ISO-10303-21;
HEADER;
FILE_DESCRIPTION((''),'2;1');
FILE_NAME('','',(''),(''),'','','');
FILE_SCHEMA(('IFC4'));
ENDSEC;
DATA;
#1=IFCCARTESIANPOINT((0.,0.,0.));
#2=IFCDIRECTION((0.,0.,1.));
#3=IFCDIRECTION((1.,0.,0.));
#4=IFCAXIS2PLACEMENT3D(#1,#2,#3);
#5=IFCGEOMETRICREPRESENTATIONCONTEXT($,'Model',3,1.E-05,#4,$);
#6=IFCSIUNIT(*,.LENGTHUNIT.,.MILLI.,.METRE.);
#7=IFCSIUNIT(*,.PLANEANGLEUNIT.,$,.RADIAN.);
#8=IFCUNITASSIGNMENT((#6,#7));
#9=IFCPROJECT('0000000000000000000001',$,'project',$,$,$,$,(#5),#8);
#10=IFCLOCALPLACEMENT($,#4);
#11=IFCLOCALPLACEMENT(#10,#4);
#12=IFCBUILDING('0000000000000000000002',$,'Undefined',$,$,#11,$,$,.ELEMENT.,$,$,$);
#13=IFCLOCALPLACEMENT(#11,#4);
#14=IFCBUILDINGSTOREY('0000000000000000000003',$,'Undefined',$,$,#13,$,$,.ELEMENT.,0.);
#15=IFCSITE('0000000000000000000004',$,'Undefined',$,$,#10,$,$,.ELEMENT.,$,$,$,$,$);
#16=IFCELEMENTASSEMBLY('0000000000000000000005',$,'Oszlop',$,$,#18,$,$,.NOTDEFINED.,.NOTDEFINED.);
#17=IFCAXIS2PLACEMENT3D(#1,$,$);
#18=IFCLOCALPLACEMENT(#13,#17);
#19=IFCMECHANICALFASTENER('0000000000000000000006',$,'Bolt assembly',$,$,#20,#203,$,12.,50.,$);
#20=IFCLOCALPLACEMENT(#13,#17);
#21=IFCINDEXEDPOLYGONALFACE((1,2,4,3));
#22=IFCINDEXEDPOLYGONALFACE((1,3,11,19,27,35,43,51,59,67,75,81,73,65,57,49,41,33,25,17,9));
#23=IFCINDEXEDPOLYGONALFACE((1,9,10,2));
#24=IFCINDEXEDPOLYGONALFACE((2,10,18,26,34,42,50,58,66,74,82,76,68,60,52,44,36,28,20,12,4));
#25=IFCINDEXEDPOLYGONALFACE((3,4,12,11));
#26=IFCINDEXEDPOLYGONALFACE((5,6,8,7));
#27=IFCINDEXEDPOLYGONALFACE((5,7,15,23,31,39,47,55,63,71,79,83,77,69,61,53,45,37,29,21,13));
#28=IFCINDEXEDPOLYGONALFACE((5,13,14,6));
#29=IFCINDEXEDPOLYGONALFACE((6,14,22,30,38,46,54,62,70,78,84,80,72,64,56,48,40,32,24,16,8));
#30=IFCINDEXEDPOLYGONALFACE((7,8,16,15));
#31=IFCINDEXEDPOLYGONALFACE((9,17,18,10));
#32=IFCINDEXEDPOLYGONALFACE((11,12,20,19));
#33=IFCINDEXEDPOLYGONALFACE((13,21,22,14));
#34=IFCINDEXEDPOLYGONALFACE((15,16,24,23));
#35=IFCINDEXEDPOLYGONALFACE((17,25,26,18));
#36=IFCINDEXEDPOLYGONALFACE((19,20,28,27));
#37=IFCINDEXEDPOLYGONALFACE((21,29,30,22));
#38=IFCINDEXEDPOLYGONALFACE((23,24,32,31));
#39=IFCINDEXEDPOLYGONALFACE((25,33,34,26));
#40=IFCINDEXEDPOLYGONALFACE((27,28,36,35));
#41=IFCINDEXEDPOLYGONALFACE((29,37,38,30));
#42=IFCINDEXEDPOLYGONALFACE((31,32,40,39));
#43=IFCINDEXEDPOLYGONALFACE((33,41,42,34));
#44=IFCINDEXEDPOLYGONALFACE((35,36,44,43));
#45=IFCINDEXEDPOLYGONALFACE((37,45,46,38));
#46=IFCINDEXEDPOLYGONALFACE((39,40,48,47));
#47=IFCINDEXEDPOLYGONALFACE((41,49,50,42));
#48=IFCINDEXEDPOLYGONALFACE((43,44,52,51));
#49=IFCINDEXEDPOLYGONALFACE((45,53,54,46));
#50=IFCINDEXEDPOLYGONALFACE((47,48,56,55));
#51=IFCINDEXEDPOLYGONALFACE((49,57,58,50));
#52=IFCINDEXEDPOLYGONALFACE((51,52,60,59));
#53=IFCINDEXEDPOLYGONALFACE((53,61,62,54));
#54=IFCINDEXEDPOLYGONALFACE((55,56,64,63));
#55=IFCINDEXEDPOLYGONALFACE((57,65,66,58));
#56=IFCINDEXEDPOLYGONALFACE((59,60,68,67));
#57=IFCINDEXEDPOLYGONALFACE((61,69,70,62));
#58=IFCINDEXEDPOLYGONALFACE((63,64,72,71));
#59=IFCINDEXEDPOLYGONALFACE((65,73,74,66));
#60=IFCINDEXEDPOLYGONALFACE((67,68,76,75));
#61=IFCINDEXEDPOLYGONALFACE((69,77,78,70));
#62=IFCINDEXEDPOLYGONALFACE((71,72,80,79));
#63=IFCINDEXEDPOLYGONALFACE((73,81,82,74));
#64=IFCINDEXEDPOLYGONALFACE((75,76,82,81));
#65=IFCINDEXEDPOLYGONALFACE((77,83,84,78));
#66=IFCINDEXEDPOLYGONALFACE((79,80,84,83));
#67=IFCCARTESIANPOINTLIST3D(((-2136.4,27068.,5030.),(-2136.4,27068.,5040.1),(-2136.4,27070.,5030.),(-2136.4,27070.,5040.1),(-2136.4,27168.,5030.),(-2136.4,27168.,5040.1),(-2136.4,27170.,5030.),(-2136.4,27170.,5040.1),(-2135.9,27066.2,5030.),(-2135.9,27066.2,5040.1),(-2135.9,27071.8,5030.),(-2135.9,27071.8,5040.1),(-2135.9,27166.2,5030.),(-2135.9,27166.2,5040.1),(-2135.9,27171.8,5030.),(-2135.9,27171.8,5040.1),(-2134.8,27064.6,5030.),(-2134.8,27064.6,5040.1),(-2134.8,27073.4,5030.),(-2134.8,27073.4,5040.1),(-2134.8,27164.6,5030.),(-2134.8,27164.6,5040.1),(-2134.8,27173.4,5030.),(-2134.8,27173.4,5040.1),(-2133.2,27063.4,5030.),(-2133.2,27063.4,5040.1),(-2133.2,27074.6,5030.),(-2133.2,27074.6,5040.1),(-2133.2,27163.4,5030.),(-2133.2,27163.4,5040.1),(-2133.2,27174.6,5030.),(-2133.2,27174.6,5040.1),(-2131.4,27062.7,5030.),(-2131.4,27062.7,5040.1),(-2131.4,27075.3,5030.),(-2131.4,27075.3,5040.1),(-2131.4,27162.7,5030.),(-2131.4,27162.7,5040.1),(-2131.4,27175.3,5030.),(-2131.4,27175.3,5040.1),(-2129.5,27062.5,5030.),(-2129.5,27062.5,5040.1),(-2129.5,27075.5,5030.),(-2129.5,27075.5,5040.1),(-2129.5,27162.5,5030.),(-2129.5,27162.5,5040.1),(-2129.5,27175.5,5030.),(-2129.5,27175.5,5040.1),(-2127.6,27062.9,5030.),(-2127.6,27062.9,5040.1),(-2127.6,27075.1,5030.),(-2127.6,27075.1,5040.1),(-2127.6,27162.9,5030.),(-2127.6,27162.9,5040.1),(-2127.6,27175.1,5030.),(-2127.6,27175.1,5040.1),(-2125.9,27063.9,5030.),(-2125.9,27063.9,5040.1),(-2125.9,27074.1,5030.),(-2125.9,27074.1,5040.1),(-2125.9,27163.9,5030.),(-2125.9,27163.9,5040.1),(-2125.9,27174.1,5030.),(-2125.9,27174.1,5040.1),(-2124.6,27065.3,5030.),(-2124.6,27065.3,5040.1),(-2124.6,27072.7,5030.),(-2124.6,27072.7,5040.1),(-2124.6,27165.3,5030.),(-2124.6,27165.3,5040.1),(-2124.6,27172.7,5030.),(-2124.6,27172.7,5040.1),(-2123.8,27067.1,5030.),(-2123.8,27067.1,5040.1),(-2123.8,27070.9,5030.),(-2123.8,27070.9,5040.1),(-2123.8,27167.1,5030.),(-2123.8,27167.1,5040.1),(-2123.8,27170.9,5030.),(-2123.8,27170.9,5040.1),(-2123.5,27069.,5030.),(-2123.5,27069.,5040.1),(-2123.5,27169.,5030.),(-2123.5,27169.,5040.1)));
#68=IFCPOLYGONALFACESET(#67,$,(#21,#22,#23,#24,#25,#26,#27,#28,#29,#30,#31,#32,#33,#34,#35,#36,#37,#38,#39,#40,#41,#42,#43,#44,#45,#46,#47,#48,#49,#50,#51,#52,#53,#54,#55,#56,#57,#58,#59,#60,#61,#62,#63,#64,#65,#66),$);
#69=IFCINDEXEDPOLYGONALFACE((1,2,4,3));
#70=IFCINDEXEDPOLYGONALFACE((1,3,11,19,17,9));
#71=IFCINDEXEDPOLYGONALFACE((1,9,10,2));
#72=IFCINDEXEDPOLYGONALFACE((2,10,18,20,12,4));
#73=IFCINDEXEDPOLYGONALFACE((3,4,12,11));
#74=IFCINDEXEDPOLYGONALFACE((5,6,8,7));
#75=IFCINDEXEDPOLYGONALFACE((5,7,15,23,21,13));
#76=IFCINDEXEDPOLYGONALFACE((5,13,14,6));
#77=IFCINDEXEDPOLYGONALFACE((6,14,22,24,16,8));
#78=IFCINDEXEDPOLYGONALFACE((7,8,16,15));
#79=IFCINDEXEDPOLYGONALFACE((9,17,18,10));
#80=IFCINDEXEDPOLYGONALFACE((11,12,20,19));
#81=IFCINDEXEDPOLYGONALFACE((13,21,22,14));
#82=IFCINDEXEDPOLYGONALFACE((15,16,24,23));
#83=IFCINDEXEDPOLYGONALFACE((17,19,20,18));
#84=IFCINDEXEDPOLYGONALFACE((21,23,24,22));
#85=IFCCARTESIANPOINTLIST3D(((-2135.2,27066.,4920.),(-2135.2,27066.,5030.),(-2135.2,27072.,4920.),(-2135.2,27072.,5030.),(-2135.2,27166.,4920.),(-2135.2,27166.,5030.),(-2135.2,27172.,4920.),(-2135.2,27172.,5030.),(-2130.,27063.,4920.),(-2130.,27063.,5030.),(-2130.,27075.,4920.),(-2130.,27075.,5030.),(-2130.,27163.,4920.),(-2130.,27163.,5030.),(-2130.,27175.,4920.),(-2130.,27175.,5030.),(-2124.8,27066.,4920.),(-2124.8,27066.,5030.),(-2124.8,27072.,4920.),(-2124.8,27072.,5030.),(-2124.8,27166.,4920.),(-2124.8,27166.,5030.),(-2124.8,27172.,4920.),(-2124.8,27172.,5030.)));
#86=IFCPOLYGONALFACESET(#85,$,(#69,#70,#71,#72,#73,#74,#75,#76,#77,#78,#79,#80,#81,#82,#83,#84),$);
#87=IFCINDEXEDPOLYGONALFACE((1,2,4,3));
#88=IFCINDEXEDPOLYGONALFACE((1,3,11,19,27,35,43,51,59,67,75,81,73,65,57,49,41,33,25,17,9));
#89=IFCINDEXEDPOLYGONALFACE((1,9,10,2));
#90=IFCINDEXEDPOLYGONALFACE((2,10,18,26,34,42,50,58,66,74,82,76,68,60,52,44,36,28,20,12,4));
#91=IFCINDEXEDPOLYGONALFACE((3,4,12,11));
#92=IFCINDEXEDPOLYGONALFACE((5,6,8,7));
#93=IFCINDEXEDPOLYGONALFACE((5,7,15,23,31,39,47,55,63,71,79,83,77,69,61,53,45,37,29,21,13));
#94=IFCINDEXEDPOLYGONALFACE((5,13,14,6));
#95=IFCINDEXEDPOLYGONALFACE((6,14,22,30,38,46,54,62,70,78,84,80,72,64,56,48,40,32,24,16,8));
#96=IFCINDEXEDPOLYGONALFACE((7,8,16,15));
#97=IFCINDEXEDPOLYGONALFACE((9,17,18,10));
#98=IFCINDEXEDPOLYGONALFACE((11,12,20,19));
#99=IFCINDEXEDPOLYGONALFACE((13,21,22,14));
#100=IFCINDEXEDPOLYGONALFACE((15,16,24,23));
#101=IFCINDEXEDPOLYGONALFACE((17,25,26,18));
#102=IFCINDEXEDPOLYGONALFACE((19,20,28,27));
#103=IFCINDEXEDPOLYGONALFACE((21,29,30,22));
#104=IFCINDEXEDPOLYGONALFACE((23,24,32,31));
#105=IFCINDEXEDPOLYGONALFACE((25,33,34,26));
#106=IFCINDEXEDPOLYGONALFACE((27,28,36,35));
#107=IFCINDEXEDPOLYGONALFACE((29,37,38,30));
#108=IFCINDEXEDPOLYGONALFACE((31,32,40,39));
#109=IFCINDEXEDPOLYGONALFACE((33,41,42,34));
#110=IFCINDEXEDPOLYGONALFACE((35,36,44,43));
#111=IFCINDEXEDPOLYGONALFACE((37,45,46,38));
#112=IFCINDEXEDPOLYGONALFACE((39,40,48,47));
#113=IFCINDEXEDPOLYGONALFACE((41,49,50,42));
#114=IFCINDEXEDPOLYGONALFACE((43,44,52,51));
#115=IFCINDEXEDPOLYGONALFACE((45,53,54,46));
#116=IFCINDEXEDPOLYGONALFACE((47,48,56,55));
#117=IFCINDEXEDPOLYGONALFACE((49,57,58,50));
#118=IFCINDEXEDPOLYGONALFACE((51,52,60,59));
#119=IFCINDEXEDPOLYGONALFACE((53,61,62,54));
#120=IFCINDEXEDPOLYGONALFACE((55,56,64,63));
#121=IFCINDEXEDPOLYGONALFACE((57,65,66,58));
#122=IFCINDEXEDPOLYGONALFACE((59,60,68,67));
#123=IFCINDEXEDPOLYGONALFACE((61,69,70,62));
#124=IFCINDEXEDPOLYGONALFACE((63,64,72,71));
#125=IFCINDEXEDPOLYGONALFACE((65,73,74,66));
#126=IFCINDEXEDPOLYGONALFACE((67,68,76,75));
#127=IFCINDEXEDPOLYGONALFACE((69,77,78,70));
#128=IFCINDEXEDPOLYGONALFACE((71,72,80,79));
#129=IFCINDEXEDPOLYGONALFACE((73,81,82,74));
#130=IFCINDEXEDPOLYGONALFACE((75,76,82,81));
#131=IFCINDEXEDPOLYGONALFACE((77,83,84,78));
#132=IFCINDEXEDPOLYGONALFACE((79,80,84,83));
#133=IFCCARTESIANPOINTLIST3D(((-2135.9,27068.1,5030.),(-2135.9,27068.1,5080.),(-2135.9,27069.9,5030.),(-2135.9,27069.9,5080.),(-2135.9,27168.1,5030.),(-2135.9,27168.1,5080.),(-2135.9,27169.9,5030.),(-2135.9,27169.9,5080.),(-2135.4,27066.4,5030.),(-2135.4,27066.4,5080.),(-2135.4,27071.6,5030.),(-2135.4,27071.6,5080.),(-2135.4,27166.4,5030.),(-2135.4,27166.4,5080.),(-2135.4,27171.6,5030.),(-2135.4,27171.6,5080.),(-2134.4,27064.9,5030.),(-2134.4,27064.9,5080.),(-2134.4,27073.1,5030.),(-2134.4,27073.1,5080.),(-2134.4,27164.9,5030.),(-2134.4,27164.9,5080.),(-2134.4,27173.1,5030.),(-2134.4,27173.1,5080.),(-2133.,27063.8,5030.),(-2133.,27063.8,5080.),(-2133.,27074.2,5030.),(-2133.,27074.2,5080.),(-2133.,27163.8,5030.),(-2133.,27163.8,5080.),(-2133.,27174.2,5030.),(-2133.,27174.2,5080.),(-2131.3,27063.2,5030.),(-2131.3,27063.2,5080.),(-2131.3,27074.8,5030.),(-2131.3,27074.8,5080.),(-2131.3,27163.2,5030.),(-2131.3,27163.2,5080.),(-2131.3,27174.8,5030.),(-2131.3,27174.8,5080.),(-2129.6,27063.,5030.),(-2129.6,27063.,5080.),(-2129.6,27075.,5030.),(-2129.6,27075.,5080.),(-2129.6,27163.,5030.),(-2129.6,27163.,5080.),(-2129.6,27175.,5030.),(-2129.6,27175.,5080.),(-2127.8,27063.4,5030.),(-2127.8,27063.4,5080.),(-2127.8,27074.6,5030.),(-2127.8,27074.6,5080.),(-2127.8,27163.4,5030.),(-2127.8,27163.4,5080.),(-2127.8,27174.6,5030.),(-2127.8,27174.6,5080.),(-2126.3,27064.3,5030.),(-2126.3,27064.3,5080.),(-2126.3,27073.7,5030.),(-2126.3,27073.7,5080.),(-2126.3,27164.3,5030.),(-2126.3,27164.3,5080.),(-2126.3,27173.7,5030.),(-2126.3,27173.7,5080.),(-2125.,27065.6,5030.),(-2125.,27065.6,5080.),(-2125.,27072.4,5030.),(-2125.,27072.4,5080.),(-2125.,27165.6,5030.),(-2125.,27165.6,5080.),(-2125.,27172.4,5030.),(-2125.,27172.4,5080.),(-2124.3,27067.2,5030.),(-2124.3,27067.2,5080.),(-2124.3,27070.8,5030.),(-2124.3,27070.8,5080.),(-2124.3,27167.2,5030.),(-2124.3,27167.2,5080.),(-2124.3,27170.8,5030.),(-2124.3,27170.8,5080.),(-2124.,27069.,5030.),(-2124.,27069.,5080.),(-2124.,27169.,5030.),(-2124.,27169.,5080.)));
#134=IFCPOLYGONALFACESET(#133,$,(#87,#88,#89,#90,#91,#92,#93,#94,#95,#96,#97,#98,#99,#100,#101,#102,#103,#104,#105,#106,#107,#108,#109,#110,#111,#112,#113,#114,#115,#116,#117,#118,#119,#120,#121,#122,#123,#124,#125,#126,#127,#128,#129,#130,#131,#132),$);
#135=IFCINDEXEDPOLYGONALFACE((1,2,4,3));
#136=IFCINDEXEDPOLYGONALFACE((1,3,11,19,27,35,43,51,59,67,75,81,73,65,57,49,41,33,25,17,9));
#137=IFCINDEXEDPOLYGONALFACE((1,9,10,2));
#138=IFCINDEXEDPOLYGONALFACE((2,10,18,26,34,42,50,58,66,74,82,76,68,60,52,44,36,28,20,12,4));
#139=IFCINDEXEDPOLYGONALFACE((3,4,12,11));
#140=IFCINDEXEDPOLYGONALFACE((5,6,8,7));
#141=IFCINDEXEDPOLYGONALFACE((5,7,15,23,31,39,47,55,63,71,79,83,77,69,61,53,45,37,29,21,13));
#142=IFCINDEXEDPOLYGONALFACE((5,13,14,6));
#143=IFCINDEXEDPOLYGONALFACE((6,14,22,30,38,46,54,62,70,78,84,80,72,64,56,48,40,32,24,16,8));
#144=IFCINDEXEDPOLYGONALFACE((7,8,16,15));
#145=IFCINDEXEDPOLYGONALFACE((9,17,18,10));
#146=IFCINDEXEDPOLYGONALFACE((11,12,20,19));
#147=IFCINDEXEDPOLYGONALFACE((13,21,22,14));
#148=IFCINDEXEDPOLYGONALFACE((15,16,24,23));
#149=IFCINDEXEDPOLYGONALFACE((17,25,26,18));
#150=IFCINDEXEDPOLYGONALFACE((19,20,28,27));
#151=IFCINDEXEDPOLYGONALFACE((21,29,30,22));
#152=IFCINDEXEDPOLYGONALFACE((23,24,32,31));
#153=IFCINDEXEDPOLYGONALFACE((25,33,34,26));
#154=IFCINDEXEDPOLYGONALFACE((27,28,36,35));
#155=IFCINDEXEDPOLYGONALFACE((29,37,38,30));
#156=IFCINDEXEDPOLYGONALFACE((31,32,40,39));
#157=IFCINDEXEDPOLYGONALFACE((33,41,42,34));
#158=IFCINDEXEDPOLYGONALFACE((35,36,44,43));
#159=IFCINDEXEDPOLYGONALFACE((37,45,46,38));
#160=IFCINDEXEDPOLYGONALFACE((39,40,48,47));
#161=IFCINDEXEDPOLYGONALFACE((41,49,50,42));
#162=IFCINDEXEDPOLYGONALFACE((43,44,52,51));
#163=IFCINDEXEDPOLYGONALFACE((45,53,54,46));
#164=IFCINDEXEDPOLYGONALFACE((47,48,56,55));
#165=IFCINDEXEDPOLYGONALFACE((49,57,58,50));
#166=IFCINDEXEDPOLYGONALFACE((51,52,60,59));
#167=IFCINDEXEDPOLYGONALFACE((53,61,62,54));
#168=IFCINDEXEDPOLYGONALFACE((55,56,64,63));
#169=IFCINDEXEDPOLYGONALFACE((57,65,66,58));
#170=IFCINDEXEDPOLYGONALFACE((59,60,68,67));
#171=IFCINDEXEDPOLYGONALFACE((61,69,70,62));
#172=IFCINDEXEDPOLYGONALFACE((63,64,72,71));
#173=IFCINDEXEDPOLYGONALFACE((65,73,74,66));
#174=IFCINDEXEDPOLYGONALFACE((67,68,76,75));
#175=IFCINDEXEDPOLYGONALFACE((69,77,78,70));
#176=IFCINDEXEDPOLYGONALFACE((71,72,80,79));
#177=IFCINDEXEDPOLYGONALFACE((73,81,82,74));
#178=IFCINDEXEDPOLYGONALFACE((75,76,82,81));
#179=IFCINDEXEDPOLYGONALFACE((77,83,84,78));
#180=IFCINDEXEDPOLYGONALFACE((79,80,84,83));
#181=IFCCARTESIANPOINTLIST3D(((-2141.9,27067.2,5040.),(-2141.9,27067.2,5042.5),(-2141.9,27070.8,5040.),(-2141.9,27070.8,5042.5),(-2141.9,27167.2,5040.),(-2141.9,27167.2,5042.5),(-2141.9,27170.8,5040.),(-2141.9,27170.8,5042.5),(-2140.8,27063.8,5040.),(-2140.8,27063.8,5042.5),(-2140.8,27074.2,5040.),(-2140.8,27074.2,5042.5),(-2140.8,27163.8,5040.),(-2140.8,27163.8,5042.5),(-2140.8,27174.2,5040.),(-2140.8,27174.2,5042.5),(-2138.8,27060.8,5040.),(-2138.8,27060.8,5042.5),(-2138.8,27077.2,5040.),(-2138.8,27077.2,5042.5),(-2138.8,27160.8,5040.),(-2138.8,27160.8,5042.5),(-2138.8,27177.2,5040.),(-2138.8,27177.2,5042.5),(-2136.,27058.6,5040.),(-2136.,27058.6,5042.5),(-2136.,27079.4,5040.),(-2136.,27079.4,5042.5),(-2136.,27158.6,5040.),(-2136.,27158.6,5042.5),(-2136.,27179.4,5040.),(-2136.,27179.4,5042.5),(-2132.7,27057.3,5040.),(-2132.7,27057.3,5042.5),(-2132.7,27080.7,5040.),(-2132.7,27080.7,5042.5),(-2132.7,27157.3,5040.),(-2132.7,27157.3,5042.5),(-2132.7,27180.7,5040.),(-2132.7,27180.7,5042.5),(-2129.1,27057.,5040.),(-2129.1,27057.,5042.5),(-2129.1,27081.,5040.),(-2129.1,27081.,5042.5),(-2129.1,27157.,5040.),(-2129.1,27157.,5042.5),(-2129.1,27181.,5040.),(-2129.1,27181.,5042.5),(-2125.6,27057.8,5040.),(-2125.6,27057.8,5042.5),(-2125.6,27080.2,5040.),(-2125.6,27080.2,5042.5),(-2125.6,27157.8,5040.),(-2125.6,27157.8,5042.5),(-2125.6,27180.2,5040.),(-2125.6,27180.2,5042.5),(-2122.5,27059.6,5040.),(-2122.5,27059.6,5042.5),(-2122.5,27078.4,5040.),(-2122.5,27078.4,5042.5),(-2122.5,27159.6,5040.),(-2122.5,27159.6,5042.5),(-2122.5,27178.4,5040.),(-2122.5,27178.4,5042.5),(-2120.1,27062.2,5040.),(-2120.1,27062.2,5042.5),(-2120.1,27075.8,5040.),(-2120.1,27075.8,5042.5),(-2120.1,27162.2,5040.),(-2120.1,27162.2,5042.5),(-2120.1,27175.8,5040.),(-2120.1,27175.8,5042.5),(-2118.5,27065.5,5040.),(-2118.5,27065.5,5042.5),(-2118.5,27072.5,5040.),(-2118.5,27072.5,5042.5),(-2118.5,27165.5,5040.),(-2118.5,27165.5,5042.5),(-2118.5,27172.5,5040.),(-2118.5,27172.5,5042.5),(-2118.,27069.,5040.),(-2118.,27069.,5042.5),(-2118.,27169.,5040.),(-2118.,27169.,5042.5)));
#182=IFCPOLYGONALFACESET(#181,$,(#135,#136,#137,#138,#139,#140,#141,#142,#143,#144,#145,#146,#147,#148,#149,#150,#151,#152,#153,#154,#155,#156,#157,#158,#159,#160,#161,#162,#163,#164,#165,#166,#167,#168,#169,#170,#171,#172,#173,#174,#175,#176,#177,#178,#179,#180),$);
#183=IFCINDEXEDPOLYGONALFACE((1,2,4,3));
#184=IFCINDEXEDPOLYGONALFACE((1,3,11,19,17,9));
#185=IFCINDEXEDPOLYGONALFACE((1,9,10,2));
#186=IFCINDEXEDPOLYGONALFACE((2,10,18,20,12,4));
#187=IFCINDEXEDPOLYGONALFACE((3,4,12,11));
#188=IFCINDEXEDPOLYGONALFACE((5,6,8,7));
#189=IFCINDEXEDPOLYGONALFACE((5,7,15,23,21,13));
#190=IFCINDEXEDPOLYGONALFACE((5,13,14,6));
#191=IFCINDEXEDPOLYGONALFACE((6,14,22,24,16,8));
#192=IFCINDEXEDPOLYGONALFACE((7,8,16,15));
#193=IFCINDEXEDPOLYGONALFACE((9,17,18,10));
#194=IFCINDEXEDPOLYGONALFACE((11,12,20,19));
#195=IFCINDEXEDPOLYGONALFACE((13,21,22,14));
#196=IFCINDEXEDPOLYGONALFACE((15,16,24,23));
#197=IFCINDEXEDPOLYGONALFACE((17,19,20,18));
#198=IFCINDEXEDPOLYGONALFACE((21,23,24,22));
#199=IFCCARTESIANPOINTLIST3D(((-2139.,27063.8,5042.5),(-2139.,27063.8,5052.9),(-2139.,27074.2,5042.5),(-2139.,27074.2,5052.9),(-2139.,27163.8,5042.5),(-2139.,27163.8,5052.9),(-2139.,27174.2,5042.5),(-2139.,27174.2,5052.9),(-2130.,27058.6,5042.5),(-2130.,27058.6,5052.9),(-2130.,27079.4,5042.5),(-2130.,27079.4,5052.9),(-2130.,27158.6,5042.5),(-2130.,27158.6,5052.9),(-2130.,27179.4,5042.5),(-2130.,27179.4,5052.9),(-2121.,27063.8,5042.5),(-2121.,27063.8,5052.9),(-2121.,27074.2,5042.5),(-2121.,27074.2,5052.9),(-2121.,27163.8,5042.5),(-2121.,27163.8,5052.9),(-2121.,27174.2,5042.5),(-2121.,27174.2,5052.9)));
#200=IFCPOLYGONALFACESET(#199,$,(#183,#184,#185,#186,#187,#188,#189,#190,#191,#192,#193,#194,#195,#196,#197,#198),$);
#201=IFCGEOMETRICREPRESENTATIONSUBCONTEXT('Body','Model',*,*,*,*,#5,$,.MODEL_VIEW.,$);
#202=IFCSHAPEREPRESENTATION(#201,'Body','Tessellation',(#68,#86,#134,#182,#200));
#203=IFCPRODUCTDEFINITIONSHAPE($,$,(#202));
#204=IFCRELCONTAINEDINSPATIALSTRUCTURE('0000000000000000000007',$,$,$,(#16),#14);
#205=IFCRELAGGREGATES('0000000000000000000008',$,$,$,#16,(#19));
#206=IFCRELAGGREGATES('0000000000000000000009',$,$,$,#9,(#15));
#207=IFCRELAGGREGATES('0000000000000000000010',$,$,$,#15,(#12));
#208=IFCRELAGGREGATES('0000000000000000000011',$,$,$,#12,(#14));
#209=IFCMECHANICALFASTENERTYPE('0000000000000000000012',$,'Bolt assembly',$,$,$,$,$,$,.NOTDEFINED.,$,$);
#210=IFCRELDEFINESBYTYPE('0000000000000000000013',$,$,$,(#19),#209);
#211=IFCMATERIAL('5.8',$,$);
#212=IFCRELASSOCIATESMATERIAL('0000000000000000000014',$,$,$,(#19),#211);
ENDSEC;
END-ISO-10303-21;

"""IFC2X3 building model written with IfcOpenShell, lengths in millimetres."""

from ifc_helpers import new_model, si_unit, frame, origin_with_axes, origin_2d_with_axis, place, context, subcontext, project, spatial, polyline, circle, outline, extrude, source, transform, mapped, material, type_object, element, aggregate, save


model = new_model("IFC2X3")

# Units and contexts
model_context = context("Model", 3, precision=1e-05, world=origin_with_axes())
body_context = subcontext(model_context, "Body", "Model", "MODEL_VIEW")
ifc_project = project(units=[si_unit("LENGTHUNIT", "METRE", prefix="MILLI"), si_unit("PLANEANGLEUNIT", "RADIAN")], contexts=[model_context])

# Site, building, storey
site_placement = place(None, origin_with_axes())
site = spatial("IfcSite", under=ifc_project, at=site_placement, Name="Undefined", CompositionType="ELEMENT")
building_placement = place(site_placement, origin_with_axes())
building = spatial("IfcBuilding", under=site, at=building_placement, Name="Undefined", CompositionType="ELEMENT")
storey_placement = place(building_placement, origin_with_axes())
storey = spatial("IfcBuildingStorey", under=building, at=storey_placement, Name="Undefined", CompositionType="ELEMENT", Elevation=0.0)

# Element assembly
assembly_1_placement = place(storey_placement, origin_with_axes())
assembly_1 = element("IfcElementAssembly", 1, at=assembly_1_placement, inside=storey, Name="Oszlop", AssemblyPlace="NOTDEFINED", PredefinedType="NOTDEFINED")

# Mechanical fastener
ifc_material_1 = material(Name="5.8")
mechanical_fastener_type = type_object("IfcMechanicalFastenerType", Name="Bolt assembly")
shared_shape_1 = source(origin_with_axes(), body_context, "Body", "SweptSolid", [
    extrude(circle(Radius=6.5, at=origin_2d_with_axis()), frame((0.0, -10.0, 0.0), z_axis=(0.0, 1.0, 0.0), x_axis=(1.0, 0.0, 0.0)), (0.0, 0.0, 1.0), 10.1),
    extrude(outline(polyline([(5.2, -3.0), (5.2, 3.0), (0.0, 6.0), (-5.2, 3.0), (-5.2, -3.0), (0.0, -6.0), (5.2, -3.0)])), frame((0.0, -120.0, 0.0), z_axis=(0.0, 1.0, 0.0), x_axis=(1.0, 0.0, 0.0)), (0.0, 0.0, 1.0), 110.0),
    extrude(circle(Radius=6.0, at=origin_2d_with_axis()), frame((0.0, -10.0, 0.0), z_axis=(0.0, 1.0, 0.0), x_axis=(1.0, 0.0, 0.0)), (0.0, 0.0, 1.0), 50.0),
    extrude(circle(Radius=12.0, at=origin_2d_with_axis()), frame((0.0, 0.0, 0.0), z_axis=(0.0, 1.0, 0.0), x_axis=(1.0, 0.0, 0.0)), (0.0, 0.0, 1.0), 2.5),
    extrude(outline(polyline([(9.0, -5.2), (9.0, 5.2), (0.0, 10.4), (-9.0, 5.2), (-9.0, -5.2), (0.0, -10.4), (9.0, -5.2)])), frame((0.0, 2.5, 0.0), z_axis=(0.0, 1.0, 0.0), x_axis=(1.0, 0.0, 0.0)), (0.0, 0.0, 1.0), 10.4),
])
mechanical_fastener_1_placement = place(assembly_1_placement, frame((-2178.0, 27119.0, 5040.0), z_axis=(0.0, -1.0, 0.0), x_axis=(1.0, 0.0, 0.0)))
mechanical_fastener_1 = element("IfcMechanicalFastener", 2, at=mechanical_fastener_1_placement, type_object=mechanical_fastener_type, material=ifc_material_1, Name="Bolt assembly", NominalDiameter=12.0, NominalLength=50.0, context=body_context, shape_type="MappedRepresentation", body=[
    mapped(shared_shape_1, transform((48.0, 0.0, -50.0))),
    mapped(shared_shape_1, transform((48.0, 0.0, 50.0))),
])
aggregate(assembly_1, [mechanical_fastener_1])

save(model, "model.ifc")
